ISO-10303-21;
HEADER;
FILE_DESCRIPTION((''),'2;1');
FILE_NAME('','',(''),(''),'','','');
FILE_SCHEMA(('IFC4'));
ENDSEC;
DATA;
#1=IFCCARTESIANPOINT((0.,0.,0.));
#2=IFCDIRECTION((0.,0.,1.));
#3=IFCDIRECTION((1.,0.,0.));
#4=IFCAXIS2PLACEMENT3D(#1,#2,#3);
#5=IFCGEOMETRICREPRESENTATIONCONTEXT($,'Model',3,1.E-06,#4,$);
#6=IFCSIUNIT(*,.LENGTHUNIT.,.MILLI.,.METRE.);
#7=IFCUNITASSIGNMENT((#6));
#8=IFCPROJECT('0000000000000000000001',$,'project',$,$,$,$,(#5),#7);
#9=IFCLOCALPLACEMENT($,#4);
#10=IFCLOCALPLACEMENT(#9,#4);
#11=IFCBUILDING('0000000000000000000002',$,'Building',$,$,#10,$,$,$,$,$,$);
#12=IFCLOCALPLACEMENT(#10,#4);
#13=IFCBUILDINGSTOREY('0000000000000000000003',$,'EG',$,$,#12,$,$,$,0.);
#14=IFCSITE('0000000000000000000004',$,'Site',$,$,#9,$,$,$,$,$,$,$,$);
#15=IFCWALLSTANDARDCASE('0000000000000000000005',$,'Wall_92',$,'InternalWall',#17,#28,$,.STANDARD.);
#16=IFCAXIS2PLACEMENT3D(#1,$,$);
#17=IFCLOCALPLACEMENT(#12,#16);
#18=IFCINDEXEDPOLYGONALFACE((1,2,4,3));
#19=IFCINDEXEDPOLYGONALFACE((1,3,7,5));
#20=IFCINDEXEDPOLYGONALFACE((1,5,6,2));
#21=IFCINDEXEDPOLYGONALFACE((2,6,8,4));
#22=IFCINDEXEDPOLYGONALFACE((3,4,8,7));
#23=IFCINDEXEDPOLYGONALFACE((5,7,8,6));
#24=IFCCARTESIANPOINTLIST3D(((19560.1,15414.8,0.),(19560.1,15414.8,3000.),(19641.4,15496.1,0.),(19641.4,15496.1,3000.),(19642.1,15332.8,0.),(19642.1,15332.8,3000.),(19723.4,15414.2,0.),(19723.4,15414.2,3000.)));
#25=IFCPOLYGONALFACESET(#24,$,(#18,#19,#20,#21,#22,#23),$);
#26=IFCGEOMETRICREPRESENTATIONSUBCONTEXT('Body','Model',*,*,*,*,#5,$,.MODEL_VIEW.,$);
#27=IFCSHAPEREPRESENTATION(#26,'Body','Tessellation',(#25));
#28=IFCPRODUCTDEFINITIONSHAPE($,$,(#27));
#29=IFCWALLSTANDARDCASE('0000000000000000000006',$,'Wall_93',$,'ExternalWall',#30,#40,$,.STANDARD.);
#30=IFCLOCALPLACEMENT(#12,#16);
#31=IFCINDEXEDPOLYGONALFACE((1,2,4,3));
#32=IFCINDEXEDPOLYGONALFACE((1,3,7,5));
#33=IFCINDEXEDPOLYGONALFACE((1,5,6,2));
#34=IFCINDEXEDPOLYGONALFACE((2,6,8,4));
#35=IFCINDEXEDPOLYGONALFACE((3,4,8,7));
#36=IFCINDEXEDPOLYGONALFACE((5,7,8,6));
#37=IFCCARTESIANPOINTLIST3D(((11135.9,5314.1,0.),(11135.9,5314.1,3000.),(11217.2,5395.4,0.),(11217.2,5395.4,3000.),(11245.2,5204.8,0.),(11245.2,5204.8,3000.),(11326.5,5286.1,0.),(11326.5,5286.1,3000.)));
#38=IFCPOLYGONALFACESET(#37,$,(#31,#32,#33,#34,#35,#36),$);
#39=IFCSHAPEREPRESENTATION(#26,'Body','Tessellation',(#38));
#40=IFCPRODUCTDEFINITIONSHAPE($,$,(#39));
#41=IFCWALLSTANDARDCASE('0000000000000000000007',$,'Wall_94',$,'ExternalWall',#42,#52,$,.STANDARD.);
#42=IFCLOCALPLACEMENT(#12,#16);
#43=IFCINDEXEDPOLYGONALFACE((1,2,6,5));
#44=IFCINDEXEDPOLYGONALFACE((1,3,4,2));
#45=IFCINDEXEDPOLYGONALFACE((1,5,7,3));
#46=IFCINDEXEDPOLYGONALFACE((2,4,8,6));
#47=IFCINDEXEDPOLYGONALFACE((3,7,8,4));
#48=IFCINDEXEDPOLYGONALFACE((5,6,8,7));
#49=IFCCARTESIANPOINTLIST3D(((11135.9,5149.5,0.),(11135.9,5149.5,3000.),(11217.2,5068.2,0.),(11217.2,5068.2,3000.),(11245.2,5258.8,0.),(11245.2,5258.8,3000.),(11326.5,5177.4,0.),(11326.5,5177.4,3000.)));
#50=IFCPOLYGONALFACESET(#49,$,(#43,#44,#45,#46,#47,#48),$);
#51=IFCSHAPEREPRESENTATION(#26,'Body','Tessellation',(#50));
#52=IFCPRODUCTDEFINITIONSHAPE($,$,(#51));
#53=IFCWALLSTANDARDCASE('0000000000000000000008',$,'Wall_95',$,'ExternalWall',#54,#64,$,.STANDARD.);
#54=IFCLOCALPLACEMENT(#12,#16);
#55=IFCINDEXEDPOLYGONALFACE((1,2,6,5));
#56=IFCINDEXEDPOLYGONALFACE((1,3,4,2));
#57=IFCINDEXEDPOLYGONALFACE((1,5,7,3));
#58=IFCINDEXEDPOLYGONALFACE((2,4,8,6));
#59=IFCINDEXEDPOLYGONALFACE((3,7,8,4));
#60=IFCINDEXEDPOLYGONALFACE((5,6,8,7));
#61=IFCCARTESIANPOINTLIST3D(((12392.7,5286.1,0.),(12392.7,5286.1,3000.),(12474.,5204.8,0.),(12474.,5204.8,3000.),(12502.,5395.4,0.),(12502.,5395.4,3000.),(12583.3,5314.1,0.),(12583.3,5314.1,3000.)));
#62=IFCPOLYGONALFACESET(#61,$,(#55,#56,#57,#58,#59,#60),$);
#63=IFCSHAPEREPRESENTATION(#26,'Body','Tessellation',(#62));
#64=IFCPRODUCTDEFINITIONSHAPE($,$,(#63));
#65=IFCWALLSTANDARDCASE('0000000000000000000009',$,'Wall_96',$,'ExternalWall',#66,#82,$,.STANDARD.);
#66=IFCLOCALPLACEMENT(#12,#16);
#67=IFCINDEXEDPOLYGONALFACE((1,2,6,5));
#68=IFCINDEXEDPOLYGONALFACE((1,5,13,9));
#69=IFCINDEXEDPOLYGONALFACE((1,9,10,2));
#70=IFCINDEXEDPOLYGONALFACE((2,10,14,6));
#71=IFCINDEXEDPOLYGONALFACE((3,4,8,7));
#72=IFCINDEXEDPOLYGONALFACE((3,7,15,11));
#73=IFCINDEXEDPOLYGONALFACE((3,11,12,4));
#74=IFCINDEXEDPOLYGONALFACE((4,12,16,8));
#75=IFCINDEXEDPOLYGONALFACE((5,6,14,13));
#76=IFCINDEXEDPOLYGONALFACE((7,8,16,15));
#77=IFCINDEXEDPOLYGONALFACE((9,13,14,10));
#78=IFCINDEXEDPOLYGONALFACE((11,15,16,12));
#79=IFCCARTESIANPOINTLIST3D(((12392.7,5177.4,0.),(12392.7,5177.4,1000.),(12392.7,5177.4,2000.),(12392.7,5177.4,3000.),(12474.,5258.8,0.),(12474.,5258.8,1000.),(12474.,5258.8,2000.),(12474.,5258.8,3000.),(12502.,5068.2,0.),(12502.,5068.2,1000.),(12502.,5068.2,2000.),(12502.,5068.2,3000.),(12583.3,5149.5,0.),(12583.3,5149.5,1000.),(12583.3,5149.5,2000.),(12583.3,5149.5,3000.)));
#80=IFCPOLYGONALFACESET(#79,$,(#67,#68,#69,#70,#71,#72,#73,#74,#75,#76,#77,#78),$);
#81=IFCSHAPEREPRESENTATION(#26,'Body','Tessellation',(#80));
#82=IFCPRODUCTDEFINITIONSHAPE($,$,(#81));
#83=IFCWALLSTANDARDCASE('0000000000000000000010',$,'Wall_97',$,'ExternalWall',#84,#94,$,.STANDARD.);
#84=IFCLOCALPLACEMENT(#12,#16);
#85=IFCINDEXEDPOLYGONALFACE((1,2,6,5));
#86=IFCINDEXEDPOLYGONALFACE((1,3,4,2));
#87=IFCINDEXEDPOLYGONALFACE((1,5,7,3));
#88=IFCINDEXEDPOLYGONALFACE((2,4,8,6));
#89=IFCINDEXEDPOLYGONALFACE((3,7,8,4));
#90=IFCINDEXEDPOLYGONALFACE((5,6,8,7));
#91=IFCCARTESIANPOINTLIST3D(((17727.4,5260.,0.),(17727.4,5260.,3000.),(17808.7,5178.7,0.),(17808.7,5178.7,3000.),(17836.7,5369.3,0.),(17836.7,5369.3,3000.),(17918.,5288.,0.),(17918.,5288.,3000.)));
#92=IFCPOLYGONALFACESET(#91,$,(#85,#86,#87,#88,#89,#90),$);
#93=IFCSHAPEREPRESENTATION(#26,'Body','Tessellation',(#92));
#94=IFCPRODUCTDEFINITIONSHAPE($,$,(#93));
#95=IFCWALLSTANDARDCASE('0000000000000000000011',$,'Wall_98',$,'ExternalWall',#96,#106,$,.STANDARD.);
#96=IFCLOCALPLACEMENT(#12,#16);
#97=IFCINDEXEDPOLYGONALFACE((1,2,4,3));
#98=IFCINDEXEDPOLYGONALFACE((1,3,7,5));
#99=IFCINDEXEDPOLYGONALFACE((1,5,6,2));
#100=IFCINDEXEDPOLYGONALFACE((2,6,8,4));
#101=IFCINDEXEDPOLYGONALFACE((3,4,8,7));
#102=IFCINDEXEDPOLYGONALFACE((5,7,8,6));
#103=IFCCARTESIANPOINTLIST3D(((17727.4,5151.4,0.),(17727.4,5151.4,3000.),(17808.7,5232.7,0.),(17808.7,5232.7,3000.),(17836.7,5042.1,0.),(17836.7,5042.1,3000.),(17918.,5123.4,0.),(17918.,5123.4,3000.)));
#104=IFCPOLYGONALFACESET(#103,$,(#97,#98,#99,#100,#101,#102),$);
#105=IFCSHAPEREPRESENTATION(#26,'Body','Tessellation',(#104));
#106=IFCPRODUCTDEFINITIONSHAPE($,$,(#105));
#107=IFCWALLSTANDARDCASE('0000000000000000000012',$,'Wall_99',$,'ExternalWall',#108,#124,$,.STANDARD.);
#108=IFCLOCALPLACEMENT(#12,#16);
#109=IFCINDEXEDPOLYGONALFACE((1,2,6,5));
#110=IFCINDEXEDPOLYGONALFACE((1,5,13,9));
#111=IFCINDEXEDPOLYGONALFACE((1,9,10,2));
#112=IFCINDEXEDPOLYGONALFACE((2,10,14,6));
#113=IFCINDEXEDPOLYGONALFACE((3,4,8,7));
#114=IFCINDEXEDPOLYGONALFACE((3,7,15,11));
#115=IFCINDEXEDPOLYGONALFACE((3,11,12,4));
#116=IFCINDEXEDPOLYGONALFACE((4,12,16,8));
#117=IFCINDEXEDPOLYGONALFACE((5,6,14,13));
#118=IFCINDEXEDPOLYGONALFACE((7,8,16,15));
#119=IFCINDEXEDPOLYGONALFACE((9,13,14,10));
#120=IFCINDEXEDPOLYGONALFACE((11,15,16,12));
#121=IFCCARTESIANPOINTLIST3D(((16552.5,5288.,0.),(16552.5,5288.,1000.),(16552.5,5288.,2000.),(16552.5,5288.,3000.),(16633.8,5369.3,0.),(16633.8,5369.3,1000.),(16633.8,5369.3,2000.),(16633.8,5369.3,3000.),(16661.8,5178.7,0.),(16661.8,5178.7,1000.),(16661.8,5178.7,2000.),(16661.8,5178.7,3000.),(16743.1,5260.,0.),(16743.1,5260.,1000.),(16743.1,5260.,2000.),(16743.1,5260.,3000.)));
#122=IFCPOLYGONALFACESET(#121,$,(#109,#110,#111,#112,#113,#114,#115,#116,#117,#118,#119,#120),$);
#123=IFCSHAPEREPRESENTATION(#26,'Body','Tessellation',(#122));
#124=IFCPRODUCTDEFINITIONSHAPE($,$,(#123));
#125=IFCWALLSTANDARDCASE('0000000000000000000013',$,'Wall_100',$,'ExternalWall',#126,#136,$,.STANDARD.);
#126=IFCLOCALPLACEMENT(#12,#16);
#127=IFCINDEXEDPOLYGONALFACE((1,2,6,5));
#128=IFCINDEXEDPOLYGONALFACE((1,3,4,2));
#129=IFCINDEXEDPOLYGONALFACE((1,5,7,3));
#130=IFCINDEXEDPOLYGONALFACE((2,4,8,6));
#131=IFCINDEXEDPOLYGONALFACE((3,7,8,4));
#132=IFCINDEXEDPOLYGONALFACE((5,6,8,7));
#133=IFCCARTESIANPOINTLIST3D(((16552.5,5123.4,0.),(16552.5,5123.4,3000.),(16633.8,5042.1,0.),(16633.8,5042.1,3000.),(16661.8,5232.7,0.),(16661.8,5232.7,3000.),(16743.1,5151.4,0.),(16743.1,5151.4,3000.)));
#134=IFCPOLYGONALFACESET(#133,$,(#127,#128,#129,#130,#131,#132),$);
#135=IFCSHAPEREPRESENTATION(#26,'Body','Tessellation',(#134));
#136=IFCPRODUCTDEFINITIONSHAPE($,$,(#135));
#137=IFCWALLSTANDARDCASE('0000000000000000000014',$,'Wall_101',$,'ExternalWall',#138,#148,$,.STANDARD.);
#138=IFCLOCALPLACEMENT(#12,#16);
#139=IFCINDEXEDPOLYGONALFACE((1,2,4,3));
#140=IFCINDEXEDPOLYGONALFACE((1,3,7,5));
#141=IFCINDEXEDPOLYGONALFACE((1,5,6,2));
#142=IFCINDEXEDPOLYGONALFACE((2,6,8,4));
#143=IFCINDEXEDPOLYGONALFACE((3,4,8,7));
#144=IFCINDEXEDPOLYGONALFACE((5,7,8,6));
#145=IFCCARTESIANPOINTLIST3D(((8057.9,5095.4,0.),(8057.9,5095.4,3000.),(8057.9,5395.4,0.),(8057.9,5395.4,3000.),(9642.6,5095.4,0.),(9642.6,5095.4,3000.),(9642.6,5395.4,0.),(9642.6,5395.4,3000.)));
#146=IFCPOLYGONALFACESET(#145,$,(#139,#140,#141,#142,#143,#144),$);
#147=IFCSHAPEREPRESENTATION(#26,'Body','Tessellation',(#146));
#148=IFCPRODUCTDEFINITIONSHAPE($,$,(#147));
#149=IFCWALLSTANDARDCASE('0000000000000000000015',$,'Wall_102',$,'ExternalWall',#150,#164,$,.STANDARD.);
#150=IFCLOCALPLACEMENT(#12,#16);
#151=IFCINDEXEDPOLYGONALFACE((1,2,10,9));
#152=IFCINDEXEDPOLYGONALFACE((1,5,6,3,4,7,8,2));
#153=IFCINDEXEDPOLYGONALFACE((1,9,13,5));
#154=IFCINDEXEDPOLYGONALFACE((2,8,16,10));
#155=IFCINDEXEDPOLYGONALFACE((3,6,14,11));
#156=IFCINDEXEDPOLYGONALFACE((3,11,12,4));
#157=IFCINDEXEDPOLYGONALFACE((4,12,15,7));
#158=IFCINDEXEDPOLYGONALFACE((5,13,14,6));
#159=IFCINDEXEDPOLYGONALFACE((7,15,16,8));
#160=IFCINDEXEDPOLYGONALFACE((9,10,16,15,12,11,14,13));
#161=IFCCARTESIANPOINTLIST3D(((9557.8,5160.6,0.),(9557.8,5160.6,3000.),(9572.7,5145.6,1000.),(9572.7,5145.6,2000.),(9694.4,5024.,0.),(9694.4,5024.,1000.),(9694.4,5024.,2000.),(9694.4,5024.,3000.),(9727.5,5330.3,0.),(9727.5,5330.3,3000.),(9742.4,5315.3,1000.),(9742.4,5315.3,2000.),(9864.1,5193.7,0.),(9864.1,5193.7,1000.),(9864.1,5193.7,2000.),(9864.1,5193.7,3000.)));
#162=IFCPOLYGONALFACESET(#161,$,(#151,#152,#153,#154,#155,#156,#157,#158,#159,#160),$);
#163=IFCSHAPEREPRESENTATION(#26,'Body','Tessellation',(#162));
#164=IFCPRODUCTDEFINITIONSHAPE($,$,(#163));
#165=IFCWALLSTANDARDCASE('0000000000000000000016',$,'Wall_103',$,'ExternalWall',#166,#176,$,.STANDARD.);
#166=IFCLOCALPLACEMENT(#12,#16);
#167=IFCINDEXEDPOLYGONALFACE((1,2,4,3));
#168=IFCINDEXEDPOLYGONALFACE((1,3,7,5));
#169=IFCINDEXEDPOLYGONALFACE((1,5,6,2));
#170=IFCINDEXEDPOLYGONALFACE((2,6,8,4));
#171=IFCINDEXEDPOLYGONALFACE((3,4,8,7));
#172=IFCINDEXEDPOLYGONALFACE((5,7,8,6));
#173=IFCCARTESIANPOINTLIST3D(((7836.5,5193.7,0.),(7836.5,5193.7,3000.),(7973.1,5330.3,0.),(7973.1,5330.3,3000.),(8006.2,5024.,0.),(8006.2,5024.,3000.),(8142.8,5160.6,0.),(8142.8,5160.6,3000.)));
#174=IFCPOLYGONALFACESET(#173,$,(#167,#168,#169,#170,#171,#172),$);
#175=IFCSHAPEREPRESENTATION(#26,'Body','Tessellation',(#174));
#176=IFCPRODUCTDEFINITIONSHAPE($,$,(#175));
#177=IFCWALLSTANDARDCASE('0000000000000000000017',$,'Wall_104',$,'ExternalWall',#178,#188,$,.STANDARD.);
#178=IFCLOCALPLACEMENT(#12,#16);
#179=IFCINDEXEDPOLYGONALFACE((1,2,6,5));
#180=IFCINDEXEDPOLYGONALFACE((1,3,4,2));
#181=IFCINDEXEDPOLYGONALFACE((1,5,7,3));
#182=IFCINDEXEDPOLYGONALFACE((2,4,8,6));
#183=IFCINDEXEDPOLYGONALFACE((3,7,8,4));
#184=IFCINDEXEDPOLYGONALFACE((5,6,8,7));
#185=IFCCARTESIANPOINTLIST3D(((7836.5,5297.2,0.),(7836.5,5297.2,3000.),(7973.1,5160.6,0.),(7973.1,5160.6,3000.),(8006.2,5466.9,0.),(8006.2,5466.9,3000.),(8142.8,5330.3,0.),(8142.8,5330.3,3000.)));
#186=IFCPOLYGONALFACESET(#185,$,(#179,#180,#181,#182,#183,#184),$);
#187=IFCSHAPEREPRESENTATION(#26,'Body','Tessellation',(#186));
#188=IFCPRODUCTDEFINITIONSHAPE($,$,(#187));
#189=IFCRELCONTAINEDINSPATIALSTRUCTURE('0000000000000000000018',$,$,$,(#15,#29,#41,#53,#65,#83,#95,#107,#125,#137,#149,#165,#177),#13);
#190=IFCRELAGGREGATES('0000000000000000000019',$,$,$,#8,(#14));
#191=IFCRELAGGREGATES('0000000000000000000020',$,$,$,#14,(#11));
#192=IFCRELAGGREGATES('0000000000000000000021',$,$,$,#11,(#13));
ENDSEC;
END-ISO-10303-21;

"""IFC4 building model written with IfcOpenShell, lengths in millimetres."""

from ifc_helpers import new_model, si_unit, frame, origin_with_axes, place, context, subcontext, project, spatial, rectangle, extrude, element, save


model = new_model("IFC4")

# Units and contexts
model_context = context("Model", 3, precision=1e-06, world=origin_with_axes())
body_context = subcontext(model_context, "Body", "Model", "MODEL_VIEW")
ifc_project = project(units=[si_unit("LENGTHUNIT", "METRE", prefix="MILLI")], contexts=[model_context])

# Site, building, storey
site_placement = place(None, origin_with_axes())
site = spatial("IfcSite", under=ifc_project, at=site_placement, Name="Site")
building_placement = place(site_placement, origin_with_axes())
building = spatial("IfcBuilding", under=site, at=building_placement, Name="Building")
storey_placement = place(building_placement, origin_with_axes())
storey = spatial("IfcBuildingStorey", under=building, at=storey_placement, Name="EG", Elevation=0.0)

# Walls
wall_1_placement = place(storey_placement, origin_with_axes())
element("IfcWallStandardCase", 1, at=wall_1_placement, inside=storey, Name="Wall_92", ObjectType="InternalWall", PredefinedType="STANDARD", context=body_context, shape_type="SweptSolid", body=[
    extrude(rectangle(XDim=115.9, YDim=115.0), frame((19641.8, 15414.5, 0.0), z_axis=(0.0, 0.0, 1.0), x_axis=(-0.707107, 0.707107, 0.0)), (0.0, 0.0, 1.0), 3000.0),
])
wall_2_placement = place(storey_placement, origin_with_axes())
element("IfcWallStandardCase", 2, at=wall_2_placement, inside=storey, Name="Wall_93", ObjectType="ExternalWall", PredefinedType="STANDARD", context=body_context, shape_type="SweptSolid", body=[
    extrude(rectangle(XDim=154.6, YDim=115.0), frame((11231.2, 5300.1, 0.0), z_axis=(0.0, 0.0, 1.0), x_axis=(-0.707107, 0.707107, 0.0)), (0.0, 0.0, 1.0), 3000.0),
])
wall_3_placement = place(storey_placement, origin_with_axes())
element("IfcWallStandardCase", 3, at=wall_3_placement, inside=storey, Name="Wall_94", ObjectType="ExternalWall", PredefinedType="STANDARD", context=body_context, shape_type="SweptSolid", body=[
    extrude(rectangle(XDim=154.6, YDim=115.0), frame((11231.2, 5163.5, 0.0), z_axis=(0.0, 0.0, 1.0), x_axis=(-0.707107, -0.707107, 0.0)), (0.0, 0.0, 1.0), 3000.0),
])
wall_4_placement = place(storey_placement, origin_with_axes())
element("IfcWallStandardCase", 4, at=wall_4_placement, inside=storey, Name="Wall_95", ObjectType="ExternalWall", PredefinedType="STANDARD", context=body_context, shape_type="SweptSolid", body=[
    extrude(rectangle(XDim=154.6, YDim=115.0), frame((12488.0, 5300.1, 0.0), z_axis=(0.0, 0.0, 1.0), x_axis=(0.707107, 0.707107, 0.0)), (0.0, 0.0, 1.0), 3000.0),
])

# Wall, opening
wall_5_placement = place(storey_placement, origin_with_axes())
wall_5 = element("IfcWallStandardCase", 5, at=wall_5_placement, inside=storey, Name="Wall_96", ObjectType="ExternalWall", PredefinedType="STANDARD", context=body_context, shape_type="SweptSolid", body=[
    extrude(rectangle(XDim=154.6, YDim=115.0), frame((12488.0, 5163.5, 0.0), z_axis=(0.0, 0.0, 1.0), x_axis=(0.707107, -0.707107, 0.0)), (0.0, 0.0, 1.0), 3000.0),
])
opening_1_placement = place(wall_5_placement, origin_with_axes())
element("IfcOpeningElement", 6, at=opening_1_placement, inside=storey, cuts=wall_5, context=body_context, shape_type="SweptSolid", body=[
    extrude(rectangle(XDim=1104.9, YDim=115.0), frame((12810.1, 4841.4, 1000.0), z_axis=(0.0, 0.0, 1.0), x_axis=(0.707107, -0.707107, 0.0)), (0.0, 0.0, 1.0), 1000.0),
])

# Walls
wall_6_placement = place(storey_placement, origin_with_axes())
element("IfcWallStandardCase", 7, at=wall_6_placement, inside=storey, Name="Wall_97", ObjectType="ExternalWall", PredefinedType="STANDARD", context=body_context, shape_type="SweptSolid", body=[
    extrude(rectangle(XDim=154.6, YDim=115.0), frame((17822.7, 5274.0, 0.0), z_axis=(0.0, 0.0, 1.0), x_axis=(0.707107, 0.707107, 0.0)), (0.0, 0.0, 1.0), 3000.0),
])
wall_7_placement = place(storey_placement, origin_with_axes())
element("IfcWallStandardCase", 8, at=wall_7_placement, inside=storey, Name="Wall_98", ObjectType="ExternalWall", PredefinedType="STANDARD", context=body_context, shape_type="SweptSolid", body=[
    extrude(rectangle(XDim=154.6, YDim=115.0), frame((17822.7, 5137.4, 0.0), z_axis=(0.0, 0.0, 1.0), x_axis=(0.707107, -0.707107, 0.0)), (0.0, 0.0, 1.0), 3000.0),
])

# Wall, opening
wall_8_placement = place(storey_placement, origin_with_axes())
wall_8 = element("IfcWallStandardCase", 9, at=wall_8_placement, inside=storey, Name="Wall_99", ObjectType="ExternalWall", PredefinedType="STANDARD", context=body_context, shape_type="SweptSolid", body=[
    extrude(rectangle(XDim=154.6, YDim=115.0), frame((16647.8, 5274.0, 0.0), z_axis=(0.0, 0.0, 1.0), x_axis=(-0.707107, 0.707107, 0.0)), (0.0, 0.0, 1.0), 3000.0),
])
opening_2_placement = place(wall_8_placement, origin_with_axes())
element("IfcOpeningElement", 10, at=opening_2_placement, inside=storey, cuts=wall_8, context=body_context, shape_type="SweptSolid", body=[
    extrude(rectangle(XDim=1123.3, YDim=115.0), frame((16306.0, 5615.9, 1000.0), z_axis=(0.0, 0.0, 1.0), x_axis=(-0.707107, 0.707107, 0.0)), (0.0, 0.0, 1.0), 1000.0),
])

# Walls
wall_9_placement = place(storey_placement, origin_with_axes())
element("IfcWallStandardCase", 11, at=wall_9_placement, inside=storey, Name="Wall_100", ObjectType="ExternalWall", PredefinedType="STANDARD", context=body_context, shape_type="SweptSolid", body=[
    extrude(rectangle(XDim=154.6, YDim=115.0), frame((16647.8, 5137.4, 0.0), z_axis=(0.0, 0.0, 1.0), x_axis=(-0.707107, -0.707107, 0.0)), (0.0, 0.0, 1.0), 3000.0),
])
wall_10_placement = place(storey_placement, origin_with_axes())
element("IfcWallStandardCase", 12, at=wall_10_placement, inside=storey, Name="Wall_101", ObjectType="ExternalWall", PredefinedType="STANDARD", context=body_context, shape_type="SweptSolid", body=[
    extrude(rectangle(XDim=1584.7, YDim=300.0), frame((8850.3, 5245.4, 0.0), z_axis=(0.0, 0.0, 1.0), x_axis=(-1.0, 0.0, 0.0)), (0.0, 0.0, 1.0), 3000.0),
])

# Wall, opening
wall_11_placement = place(storey_placement, origin_with_axes())
wall_11 = element("IfcWallStandardCase", 13, at=wall_11_placement, inside=storey, Name="Wall_102", ObjectType="ExternalWall", PredefinedType="STANDARD", context=body_context, shape_type="SweptSolid", body=[
    extrude(rectangle(XDim=193.2, YDim=240.0), frame((9710.9, 5177.1, 0.0), z_axis=(0.0, 0.0, 1.0), x_axis=(0.707107, -0.707107, 0.0)), (0.0, 0.0, 1.0), 3000.0),
])
opening_3_placement = place(wall_11_placement, origin_with_axes())
element("IfcOpeningElement", 14, at=opening_3_placement, inside=storey, cuts=wall_11, context=body_context, shape_type="SweptSolid", body=[
    extrude(rectangle(XDim=1123.3, YDim=240.0), frame((10054.7, 4833.3, 1000.0), z_axis=(0.0, 0.0, 1.0), x_axis=(0.707107, -0.707107, 0.0)), (0.0, 0.0, 1.0), 1000.0),
])

# Walls
wall_12_placement = place(storey_placement, origin_with_axes())
element("IfcWallStandardCase", 15, at=wall_12_placement, inside=storey, Name="Wall_103", ObjectType="ExternalWall", PredefinedType="STANDARD", context=body_context, shape_type="SweptSolid", body=[
    extrude(rectangle(XDim=193.2, YDim=240.0), frame((7989.6, 5177.1, 0.0), z_axis=(0.0, 0.0, 1.0), x_axis=(-0.707107, -0.707107, 0.0)), (0.0, 0.0, 1.0), 3000.0),
])
wall_13_placement = place(storey_placement, origin_with_axes())
element("IfcWallStandardCase", 16, at=wall_13_placement, inside=storey, Name="Wall_104", ObjectType="ExternalWall", PredefinedType="STANDARD", context=body_context, shape_type="SweptSolid", body=[
    extrude(rectangle(XDim=193.2, YDim=240.0), frame((7989.6, 5313.7, 0.0), z_axis=(0.0, 0.0, 1.0), x_axis=(-0.707107, 0.707107, 0.0)), (0.0, 0.0, 1.0), 3000.0),
])

save(model, "model.ifc")
